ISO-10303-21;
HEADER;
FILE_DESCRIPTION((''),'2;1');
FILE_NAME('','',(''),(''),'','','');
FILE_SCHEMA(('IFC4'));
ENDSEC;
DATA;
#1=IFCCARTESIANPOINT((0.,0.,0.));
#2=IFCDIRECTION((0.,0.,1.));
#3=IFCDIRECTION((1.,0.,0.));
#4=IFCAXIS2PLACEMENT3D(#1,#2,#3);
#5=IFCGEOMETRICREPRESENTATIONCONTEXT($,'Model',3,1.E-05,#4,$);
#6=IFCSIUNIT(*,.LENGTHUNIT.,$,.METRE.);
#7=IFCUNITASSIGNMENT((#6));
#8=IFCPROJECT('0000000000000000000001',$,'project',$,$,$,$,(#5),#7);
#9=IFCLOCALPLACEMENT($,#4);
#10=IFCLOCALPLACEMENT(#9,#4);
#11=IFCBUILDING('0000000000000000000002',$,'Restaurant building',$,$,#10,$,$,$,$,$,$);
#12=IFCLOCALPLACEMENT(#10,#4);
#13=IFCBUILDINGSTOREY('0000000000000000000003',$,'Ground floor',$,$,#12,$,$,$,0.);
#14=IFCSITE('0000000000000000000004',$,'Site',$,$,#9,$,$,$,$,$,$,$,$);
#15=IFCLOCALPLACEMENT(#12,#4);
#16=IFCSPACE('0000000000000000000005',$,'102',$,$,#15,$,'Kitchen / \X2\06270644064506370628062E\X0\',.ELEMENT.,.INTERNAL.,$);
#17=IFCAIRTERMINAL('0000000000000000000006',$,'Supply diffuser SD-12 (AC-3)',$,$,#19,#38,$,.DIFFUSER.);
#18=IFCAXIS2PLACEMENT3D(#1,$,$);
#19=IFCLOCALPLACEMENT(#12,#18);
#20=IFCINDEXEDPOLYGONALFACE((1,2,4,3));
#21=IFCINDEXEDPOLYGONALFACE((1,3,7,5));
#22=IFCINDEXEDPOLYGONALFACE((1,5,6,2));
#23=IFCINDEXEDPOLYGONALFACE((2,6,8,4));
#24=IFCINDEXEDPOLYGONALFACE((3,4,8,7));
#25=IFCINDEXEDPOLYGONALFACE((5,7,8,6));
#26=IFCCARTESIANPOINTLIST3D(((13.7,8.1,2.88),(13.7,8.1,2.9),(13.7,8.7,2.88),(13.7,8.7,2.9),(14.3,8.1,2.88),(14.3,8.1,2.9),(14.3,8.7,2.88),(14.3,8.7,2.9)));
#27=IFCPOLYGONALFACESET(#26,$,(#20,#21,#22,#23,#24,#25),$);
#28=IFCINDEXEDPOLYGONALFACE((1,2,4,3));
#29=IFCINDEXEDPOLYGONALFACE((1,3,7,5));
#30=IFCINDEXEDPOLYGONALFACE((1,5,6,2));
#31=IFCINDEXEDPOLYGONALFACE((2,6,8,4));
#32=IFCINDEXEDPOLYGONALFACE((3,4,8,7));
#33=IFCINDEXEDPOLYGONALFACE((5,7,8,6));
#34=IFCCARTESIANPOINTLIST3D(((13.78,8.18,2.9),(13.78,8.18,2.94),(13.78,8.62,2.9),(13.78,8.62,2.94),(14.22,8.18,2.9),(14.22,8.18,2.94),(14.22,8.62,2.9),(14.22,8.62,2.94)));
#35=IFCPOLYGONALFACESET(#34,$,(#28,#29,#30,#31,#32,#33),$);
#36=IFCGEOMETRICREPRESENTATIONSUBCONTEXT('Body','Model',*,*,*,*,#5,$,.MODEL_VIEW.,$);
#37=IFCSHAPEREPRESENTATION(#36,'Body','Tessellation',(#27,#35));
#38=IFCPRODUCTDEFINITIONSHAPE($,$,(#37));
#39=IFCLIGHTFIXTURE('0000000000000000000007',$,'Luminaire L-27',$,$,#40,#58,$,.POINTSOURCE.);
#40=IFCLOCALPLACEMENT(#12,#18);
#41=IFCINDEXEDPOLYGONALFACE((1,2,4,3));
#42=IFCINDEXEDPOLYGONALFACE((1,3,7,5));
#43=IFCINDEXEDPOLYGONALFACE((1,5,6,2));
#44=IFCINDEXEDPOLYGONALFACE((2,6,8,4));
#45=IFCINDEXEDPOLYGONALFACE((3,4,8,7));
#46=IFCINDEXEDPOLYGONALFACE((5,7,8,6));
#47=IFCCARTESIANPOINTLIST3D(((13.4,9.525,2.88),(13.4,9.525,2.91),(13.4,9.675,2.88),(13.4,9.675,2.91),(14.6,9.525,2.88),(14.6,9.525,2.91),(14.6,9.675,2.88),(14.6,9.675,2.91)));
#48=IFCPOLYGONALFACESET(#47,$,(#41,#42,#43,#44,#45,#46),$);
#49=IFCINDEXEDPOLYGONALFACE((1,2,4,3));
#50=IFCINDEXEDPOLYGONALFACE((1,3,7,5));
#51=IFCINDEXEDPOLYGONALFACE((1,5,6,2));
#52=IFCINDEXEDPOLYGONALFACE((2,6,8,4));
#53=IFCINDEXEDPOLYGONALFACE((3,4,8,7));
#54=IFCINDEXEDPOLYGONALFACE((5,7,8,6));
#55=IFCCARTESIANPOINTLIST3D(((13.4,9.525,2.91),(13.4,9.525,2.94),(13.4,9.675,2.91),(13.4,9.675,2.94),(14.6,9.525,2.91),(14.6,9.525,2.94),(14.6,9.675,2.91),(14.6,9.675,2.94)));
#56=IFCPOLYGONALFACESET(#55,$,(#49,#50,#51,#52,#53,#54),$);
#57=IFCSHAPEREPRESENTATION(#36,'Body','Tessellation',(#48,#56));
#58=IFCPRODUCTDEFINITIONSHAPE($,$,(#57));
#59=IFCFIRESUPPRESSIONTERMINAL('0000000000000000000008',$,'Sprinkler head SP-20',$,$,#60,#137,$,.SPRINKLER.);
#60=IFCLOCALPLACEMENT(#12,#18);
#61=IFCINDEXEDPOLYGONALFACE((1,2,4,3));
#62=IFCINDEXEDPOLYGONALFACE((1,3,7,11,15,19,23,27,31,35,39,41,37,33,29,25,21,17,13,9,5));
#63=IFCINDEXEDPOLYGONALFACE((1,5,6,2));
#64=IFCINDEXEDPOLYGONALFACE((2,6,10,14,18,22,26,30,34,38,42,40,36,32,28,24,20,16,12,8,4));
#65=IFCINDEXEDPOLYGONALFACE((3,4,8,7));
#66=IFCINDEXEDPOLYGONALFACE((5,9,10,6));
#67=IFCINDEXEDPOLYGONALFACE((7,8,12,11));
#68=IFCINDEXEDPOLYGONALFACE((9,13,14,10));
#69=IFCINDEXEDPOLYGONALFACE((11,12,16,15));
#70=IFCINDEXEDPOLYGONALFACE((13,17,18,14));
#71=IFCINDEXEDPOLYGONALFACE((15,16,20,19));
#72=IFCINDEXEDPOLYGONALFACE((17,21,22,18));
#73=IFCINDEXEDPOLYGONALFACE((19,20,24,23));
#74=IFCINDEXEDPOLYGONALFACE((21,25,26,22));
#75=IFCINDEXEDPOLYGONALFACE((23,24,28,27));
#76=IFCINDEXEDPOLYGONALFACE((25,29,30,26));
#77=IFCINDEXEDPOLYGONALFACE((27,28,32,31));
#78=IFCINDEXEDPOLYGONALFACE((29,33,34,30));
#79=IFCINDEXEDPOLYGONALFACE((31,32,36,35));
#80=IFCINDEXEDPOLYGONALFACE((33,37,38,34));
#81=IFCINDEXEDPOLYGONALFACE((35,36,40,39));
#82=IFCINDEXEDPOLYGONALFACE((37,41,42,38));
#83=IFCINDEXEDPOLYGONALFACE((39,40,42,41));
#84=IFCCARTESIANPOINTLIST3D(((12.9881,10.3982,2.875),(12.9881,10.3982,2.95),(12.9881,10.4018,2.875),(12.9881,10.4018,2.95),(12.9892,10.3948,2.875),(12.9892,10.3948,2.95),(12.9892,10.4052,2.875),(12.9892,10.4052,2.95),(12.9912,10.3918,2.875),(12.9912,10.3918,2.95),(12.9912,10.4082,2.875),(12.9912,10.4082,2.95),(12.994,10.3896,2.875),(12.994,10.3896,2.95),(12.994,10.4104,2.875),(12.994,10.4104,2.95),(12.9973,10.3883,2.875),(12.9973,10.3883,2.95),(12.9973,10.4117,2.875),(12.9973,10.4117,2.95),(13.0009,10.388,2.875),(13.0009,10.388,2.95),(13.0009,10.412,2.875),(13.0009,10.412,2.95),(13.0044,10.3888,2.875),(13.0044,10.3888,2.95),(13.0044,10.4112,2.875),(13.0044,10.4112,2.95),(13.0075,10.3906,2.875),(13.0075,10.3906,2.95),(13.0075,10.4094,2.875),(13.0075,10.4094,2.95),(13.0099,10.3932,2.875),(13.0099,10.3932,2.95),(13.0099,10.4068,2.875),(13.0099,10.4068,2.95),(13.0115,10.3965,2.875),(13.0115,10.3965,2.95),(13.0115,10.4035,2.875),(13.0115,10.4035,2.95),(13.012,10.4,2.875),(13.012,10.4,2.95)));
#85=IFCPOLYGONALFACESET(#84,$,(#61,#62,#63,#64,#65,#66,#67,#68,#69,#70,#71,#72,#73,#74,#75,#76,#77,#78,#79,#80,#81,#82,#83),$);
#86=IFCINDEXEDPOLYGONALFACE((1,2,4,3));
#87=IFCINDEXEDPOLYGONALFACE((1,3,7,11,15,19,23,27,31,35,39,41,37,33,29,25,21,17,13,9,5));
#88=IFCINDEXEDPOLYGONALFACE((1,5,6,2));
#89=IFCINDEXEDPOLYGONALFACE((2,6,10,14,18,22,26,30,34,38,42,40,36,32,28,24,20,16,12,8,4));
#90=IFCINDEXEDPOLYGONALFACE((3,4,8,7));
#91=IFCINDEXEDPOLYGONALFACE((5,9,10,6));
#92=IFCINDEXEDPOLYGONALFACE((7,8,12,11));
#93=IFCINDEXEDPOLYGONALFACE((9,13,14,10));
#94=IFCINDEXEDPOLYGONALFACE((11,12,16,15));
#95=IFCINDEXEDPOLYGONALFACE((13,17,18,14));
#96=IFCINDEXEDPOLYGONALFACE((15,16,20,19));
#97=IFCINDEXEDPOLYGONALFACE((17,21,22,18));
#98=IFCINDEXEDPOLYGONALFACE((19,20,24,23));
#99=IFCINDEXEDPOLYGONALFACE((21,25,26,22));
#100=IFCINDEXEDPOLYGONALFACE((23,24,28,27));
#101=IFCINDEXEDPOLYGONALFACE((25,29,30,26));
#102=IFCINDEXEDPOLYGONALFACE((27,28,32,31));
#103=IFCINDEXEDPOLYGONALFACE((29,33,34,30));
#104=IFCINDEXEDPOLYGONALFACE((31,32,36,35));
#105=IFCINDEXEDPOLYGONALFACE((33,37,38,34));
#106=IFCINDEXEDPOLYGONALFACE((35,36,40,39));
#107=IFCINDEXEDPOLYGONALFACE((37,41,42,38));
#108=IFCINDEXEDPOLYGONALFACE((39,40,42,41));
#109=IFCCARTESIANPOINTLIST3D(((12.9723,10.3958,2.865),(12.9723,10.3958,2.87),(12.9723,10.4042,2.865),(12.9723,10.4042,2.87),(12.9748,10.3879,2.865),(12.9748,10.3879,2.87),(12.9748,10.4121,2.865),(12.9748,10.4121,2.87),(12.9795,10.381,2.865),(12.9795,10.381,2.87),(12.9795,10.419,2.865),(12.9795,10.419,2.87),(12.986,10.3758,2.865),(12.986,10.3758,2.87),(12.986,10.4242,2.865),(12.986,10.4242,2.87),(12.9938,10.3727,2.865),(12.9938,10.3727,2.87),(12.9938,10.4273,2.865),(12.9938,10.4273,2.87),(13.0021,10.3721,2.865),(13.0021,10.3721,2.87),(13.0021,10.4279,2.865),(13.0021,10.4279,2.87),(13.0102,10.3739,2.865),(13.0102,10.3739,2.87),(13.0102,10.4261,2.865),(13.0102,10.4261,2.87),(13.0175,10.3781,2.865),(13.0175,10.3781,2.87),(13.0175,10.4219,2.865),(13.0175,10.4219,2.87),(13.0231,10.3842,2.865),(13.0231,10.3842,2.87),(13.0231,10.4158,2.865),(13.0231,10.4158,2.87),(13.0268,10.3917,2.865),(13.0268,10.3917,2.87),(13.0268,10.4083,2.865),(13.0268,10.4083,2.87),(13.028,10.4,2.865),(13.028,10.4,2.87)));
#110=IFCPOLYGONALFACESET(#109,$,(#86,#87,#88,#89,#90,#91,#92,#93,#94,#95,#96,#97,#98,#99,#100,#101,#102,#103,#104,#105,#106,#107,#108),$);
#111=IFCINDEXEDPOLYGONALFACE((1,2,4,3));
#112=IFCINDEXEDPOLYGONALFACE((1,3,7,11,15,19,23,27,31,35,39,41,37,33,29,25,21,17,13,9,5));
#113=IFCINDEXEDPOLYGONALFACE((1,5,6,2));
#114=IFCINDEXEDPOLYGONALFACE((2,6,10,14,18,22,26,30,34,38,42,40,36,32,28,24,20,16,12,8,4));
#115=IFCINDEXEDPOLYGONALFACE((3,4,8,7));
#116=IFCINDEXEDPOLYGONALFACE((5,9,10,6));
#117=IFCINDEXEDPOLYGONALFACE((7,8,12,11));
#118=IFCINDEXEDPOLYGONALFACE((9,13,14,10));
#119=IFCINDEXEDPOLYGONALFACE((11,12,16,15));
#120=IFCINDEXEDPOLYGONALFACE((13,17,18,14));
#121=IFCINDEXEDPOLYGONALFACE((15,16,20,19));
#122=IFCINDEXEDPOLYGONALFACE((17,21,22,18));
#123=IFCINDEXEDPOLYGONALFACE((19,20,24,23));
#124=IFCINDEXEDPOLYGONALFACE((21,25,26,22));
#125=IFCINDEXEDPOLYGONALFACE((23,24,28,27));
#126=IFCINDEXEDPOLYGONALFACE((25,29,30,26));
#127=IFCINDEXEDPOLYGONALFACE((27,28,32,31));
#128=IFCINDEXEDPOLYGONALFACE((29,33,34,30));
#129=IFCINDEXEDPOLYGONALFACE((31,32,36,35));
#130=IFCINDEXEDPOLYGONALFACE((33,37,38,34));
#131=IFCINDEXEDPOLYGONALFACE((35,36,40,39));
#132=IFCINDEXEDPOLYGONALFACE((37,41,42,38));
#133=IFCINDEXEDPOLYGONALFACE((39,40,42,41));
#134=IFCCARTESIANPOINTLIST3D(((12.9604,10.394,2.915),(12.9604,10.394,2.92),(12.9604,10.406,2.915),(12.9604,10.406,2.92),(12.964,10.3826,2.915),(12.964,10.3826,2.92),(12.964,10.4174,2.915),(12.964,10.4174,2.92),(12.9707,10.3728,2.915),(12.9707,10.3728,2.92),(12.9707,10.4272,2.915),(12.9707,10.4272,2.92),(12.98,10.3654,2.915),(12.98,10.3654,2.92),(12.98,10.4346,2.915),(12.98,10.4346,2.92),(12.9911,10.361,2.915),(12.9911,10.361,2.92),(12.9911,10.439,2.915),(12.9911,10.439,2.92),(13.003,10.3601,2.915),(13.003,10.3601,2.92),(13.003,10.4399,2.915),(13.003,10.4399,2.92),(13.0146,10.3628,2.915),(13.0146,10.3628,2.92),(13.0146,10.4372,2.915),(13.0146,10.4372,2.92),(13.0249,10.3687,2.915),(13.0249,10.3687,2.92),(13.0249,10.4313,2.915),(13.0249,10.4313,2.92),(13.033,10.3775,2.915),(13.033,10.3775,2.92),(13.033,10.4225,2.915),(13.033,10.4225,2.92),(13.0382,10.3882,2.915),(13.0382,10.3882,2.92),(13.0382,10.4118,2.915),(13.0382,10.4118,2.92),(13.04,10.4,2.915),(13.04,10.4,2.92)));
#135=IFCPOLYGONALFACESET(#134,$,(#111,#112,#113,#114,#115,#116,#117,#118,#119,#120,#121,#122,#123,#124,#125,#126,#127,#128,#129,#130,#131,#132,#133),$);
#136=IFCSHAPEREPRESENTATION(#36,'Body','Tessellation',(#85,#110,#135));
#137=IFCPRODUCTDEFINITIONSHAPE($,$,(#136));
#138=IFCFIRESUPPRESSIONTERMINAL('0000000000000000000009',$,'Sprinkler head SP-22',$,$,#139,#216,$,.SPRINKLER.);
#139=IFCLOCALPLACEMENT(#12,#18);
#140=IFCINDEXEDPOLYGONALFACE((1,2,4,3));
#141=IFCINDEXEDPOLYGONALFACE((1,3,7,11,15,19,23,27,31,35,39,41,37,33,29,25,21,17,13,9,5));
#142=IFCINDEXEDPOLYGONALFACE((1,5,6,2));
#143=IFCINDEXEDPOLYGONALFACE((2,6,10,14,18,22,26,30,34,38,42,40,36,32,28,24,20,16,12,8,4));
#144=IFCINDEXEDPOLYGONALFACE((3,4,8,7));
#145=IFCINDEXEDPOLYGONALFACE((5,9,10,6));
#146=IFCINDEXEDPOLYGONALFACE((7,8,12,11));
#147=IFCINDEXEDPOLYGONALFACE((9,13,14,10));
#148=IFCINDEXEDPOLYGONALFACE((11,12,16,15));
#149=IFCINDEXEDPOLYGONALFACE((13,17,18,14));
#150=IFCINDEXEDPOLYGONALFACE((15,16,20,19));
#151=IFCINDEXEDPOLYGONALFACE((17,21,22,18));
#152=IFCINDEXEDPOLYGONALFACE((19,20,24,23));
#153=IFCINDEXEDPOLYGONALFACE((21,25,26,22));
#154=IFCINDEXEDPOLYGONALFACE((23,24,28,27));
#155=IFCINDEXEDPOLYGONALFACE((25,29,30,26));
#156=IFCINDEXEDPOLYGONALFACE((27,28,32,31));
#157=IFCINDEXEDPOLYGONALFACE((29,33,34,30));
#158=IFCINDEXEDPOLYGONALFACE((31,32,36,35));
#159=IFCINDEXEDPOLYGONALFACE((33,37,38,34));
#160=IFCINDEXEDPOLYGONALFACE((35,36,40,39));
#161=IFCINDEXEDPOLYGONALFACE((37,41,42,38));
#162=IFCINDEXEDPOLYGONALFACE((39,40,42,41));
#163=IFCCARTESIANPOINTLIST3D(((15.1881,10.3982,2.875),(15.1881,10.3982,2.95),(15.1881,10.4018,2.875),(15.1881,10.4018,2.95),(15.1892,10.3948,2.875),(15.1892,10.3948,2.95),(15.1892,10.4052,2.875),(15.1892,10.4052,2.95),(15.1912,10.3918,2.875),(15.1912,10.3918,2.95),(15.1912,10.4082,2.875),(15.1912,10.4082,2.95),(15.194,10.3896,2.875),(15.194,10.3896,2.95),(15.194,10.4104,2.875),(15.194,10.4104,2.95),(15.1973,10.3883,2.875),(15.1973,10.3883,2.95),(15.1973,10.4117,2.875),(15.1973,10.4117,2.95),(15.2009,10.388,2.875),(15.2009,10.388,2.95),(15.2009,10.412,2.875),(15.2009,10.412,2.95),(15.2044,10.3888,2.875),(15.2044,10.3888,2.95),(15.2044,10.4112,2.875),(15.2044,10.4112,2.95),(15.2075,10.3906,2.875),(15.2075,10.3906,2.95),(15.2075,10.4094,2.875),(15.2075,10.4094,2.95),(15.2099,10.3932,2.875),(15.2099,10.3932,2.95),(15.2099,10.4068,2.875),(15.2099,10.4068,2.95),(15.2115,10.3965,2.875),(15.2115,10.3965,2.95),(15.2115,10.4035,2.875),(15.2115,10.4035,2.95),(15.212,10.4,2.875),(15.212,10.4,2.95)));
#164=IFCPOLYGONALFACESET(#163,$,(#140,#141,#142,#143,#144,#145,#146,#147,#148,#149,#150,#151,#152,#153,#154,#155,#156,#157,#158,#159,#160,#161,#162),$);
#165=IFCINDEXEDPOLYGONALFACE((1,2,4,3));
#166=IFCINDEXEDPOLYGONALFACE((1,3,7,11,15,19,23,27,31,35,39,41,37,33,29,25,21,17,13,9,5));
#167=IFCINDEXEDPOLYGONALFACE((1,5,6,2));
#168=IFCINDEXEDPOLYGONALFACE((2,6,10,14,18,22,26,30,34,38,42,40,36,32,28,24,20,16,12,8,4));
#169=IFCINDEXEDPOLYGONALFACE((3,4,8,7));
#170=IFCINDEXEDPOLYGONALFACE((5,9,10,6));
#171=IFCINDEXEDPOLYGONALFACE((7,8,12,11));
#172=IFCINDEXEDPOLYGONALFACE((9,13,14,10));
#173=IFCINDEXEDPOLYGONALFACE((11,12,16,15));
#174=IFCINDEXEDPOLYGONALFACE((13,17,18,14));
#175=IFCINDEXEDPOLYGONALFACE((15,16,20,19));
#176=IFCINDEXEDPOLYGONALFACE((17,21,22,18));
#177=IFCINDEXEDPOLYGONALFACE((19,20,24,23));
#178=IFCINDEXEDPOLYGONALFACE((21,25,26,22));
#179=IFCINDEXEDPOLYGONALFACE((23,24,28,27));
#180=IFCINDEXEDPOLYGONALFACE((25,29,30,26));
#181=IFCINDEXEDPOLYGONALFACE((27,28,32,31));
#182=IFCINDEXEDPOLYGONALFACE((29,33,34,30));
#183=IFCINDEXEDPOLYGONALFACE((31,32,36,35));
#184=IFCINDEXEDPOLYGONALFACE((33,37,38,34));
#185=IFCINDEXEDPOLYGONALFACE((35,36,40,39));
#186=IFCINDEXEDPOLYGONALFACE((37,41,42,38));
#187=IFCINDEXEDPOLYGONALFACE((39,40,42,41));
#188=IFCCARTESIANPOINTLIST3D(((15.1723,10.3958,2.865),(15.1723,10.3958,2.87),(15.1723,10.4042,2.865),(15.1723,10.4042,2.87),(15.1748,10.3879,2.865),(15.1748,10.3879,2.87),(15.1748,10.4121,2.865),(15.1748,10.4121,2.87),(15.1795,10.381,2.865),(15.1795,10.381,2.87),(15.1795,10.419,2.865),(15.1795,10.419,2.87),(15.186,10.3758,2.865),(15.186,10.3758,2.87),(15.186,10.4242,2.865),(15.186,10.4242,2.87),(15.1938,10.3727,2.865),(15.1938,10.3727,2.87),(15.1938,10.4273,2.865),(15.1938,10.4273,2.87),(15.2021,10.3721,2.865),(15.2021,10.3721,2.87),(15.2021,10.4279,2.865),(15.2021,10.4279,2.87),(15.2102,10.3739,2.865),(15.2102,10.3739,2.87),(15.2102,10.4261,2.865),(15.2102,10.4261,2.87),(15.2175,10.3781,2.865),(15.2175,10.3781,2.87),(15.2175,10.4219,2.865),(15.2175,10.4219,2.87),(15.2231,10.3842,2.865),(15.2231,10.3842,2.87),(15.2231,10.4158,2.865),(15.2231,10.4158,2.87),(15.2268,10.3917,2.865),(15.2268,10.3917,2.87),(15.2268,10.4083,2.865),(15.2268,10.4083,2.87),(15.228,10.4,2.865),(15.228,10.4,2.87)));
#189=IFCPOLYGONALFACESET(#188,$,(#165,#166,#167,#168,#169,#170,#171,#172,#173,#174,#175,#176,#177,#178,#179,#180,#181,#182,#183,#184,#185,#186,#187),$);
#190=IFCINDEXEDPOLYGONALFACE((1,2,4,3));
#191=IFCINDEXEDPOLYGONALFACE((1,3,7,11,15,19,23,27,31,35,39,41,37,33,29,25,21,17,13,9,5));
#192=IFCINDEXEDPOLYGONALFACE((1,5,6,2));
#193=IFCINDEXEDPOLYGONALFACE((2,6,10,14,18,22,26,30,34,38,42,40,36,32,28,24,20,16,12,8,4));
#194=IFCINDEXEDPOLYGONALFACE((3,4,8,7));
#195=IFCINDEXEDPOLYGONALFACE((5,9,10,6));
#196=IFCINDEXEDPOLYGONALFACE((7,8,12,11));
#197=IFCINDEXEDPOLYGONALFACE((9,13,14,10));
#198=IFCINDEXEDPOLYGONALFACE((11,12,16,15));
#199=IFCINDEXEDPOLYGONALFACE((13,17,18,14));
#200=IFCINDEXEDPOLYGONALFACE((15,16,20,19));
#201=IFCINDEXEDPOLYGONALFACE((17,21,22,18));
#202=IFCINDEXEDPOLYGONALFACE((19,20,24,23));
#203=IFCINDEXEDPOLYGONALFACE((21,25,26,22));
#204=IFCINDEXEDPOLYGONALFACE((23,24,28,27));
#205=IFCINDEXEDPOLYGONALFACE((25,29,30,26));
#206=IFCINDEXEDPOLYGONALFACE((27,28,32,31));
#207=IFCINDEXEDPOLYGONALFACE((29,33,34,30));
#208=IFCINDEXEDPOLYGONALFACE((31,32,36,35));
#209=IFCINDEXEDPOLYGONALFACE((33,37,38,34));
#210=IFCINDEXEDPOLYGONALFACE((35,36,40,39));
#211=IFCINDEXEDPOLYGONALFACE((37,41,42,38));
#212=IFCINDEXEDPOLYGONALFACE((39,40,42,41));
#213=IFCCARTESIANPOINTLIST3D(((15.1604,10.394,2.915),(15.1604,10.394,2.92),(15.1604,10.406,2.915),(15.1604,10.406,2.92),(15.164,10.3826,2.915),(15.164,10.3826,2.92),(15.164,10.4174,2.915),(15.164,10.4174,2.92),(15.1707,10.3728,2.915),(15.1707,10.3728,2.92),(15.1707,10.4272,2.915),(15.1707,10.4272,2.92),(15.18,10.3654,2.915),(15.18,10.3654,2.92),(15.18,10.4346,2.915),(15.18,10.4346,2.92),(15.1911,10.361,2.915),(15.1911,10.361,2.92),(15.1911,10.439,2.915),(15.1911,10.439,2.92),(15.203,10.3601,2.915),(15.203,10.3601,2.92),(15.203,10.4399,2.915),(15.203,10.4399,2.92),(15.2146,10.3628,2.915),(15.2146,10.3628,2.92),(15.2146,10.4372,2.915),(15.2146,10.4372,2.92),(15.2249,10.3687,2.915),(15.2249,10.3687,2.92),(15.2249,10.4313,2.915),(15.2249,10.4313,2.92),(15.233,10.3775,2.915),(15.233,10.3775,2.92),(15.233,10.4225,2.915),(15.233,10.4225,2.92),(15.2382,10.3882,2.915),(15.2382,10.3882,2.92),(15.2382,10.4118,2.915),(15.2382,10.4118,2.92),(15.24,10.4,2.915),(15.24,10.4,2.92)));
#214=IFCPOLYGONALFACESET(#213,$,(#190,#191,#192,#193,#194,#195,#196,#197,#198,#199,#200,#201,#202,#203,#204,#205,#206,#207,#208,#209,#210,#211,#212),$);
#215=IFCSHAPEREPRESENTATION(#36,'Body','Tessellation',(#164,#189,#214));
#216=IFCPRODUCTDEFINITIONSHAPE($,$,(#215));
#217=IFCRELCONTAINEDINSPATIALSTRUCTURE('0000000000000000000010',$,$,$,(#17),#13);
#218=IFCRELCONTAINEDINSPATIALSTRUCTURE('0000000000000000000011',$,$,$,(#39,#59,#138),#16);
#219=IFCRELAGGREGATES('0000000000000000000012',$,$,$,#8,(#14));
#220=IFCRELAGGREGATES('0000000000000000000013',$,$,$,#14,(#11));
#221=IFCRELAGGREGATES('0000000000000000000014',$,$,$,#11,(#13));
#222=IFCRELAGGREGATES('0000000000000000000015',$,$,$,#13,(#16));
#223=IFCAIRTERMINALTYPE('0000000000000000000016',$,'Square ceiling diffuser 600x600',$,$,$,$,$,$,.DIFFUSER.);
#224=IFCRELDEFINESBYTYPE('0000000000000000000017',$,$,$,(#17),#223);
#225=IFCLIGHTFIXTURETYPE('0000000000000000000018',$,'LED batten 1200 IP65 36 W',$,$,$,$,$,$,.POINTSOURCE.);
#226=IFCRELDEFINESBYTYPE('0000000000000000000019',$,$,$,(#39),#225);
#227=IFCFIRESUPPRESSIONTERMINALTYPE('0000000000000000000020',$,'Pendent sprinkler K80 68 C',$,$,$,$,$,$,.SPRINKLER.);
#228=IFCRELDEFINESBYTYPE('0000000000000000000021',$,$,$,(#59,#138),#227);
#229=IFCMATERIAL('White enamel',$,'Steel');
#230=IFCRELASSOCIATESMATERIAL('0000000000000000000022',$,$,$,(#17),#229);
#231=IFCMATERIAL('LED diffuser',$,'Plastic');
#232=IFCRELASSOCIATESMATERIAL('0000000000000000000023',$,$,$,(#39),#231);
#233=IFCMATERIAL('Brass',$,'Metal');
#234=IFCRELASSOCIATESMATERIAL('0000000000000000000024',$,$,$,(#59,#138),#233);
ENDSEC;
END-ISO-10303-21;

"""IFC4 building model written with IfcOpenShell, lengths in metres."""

from ifc_helpers import new_model, si_unit, frame, origin, origin_with_axes, origin_2d, place, context, subcontext, project, spatial, rectangle, circle, extrude, source, transform, mapped, material, type_object, type_shapes, element, save


model = new_model("IFC4")

# Units and contexts
model_context = context("Model", 3, precision=1e-05, world=origin_with_axes())
body_context = subcontext(model_context, "Body", "Model", "MODEL_VIEW")
ifc_project = project(units=[si_unit("LENGTHUNIT", "METRE")], contexts=[model_context])

# Site, building, storey
site_placement = place(None, origin_with_axes())
site = spatial("IfcSite", under=ifc_project, at=site_placement, Name="Site")
building_placement = place(site_placement, origin_with_axes())
building = spatial("IfcBuilding", under=site, at=building_placement, Name="Restaurant building")
storey_placement = place(building_placement, origin_with_axes())
storey = spatial("IfcBuildingStorey", under=building, at=storey_placement, Name="Ground floor", Elevation=0.0)

# Air terminal
ifc_material_1 = material(Name="White enamel", Category="Steel")
air_terminal_type = type_object("IfcAirTerminalType", Name="Square ceiling diffuser 600x600", PredefinedType="DIFFUSER")
shared_shape_1 = source(origin(), body_context, "Body", "SweptSolid", [
    extrude(rectangle(XDim=0.6, YDim=0.6, at=origin_2d()), frame((0.0, 0.0, -0.06)), (0.0, 0.0, 1.0), 0.02),
    extrude(rectangle(XDim=0.44, YDim=0.44, at=origin_2d()), frame((0.0, 0.0, -0.04)), (0.0, 0.0, 1.0), 0.04),
])
type_shapes(air_terminal_type, [shared_shape_1])
air_terminal_placement = place(storey_placement, frame((14.0, 8.4, 2.94)))
element("IfcAirTerminal", 1, at=air_terminal_placement, inside=storey, type_object=air_terminal_type, material=ifc_material_1, Name="Supply diffuser SD-12 (AC-3)", PredefinedType="DIFFUSER", context=body_context, shape_type="MappedRepresentation", body=[
    mapped(shared_shape_1, transform((0.0, 0.0, 0.0))),
])

# Shared definitions
space_placement = place(storey_placement, origin_with_axes())
space = spatial("IfcSpace", under=storey, at=space_placement, Name="102", LongName="Kitchen / المطبخ", CompositionType="ELEMENT", PredefinedType="INTERNAL")

# Light fixture
ifc_material_2 = material(Name="LED diffuser", Category="Plastic")
light_fixture_type = type_object("IfcLightFixtureType", Name="LED batten 1200 IP65 36 W", PredefinedType="POINTSOURCE")
shared_shape_2 = source(origin(), body_context, "Body", "SweptSolid", [
    extrude(rectangle(XDim=1.2, YDim=0.15, at=origin_2d()), frame((0.0, 0.0, -0.06)), (0.0, 0.0, 1.0), 0.03),
    extrude(rectangle(XDim=1.2, YDim=0.15, at=origin_2d()), frame((0.0, 0.0, -0.03)), (0.0, 0.0, 1.0), 0.03),
])
type_shapes(light_fixture_type, [shared_shape_2])
light_fixture_placement = place(storey_placement, frame((14.0, 9.6, 2.94)))
element("IfcLightFixture", 2, at=light_fixture_placement, inside=space, type_object=light_fixture_type, material=ifc_material_2, Name="Luminaire L-27", PredefinedType="POINTSOURCE", context=body_context, shape_type="MappedRepresentation", body=[
    mapped(shared_shape_2, transform((0.0, 0.0, 0.0))),
])

# Fire suppression terminals
ifc_material_3 = material(Name="Brass", Category="Metal")
fire_suppression_terminal_type = type_object("IfcFireSuppressionTerminalType", Name="Pendent sprinkler K80 68 C", PredefinedType="SPRINKLER")
shared_shape_3 = source(origin(), body_context, "Body", "SweptSolid", [
    extrude(circle(Radius=0.012, at=origin_2d()), frame((0.0, 0.0, -0.075)), (0.0, 0.0, 1.0), 0.075),
    extrude(circle(Radius=0.028, at=origin_2d()), frame((0.0, 0.0, -0.085)), (0.0, 0.0, 1.0), 0.005),
    extrude(circle(Radius=0.04, at=origin_2d()), frame((0.0, 0.0, -0.035)), (0.0, 0.0, 1.0), 0.005),
])
type_shapes(fire_suppression_terminal_type, [shared_shape_3])
for number, where, name in (
    (3, (13.0, 10.4, 2.95), "Sprinkler head SP-20"),
    (4, (15.2, 10.4, 2.95), "Sprinkler head SP-22"),
):
    element("IfcFireSuppressionTerminal", number, at=place(storey_placement, frame(where)), inside=space, type_object=fire_suppression_terminal_type, material=ifc_material_3, Name=name, PredefinedType="SPRINKLER", context=body_context, shape_type="MappedRepresentation", body=[
        mapped(shared_shape_3, transform((0.0, 0.0, 0.0))),
    ])

save(model, "model.ifc")
